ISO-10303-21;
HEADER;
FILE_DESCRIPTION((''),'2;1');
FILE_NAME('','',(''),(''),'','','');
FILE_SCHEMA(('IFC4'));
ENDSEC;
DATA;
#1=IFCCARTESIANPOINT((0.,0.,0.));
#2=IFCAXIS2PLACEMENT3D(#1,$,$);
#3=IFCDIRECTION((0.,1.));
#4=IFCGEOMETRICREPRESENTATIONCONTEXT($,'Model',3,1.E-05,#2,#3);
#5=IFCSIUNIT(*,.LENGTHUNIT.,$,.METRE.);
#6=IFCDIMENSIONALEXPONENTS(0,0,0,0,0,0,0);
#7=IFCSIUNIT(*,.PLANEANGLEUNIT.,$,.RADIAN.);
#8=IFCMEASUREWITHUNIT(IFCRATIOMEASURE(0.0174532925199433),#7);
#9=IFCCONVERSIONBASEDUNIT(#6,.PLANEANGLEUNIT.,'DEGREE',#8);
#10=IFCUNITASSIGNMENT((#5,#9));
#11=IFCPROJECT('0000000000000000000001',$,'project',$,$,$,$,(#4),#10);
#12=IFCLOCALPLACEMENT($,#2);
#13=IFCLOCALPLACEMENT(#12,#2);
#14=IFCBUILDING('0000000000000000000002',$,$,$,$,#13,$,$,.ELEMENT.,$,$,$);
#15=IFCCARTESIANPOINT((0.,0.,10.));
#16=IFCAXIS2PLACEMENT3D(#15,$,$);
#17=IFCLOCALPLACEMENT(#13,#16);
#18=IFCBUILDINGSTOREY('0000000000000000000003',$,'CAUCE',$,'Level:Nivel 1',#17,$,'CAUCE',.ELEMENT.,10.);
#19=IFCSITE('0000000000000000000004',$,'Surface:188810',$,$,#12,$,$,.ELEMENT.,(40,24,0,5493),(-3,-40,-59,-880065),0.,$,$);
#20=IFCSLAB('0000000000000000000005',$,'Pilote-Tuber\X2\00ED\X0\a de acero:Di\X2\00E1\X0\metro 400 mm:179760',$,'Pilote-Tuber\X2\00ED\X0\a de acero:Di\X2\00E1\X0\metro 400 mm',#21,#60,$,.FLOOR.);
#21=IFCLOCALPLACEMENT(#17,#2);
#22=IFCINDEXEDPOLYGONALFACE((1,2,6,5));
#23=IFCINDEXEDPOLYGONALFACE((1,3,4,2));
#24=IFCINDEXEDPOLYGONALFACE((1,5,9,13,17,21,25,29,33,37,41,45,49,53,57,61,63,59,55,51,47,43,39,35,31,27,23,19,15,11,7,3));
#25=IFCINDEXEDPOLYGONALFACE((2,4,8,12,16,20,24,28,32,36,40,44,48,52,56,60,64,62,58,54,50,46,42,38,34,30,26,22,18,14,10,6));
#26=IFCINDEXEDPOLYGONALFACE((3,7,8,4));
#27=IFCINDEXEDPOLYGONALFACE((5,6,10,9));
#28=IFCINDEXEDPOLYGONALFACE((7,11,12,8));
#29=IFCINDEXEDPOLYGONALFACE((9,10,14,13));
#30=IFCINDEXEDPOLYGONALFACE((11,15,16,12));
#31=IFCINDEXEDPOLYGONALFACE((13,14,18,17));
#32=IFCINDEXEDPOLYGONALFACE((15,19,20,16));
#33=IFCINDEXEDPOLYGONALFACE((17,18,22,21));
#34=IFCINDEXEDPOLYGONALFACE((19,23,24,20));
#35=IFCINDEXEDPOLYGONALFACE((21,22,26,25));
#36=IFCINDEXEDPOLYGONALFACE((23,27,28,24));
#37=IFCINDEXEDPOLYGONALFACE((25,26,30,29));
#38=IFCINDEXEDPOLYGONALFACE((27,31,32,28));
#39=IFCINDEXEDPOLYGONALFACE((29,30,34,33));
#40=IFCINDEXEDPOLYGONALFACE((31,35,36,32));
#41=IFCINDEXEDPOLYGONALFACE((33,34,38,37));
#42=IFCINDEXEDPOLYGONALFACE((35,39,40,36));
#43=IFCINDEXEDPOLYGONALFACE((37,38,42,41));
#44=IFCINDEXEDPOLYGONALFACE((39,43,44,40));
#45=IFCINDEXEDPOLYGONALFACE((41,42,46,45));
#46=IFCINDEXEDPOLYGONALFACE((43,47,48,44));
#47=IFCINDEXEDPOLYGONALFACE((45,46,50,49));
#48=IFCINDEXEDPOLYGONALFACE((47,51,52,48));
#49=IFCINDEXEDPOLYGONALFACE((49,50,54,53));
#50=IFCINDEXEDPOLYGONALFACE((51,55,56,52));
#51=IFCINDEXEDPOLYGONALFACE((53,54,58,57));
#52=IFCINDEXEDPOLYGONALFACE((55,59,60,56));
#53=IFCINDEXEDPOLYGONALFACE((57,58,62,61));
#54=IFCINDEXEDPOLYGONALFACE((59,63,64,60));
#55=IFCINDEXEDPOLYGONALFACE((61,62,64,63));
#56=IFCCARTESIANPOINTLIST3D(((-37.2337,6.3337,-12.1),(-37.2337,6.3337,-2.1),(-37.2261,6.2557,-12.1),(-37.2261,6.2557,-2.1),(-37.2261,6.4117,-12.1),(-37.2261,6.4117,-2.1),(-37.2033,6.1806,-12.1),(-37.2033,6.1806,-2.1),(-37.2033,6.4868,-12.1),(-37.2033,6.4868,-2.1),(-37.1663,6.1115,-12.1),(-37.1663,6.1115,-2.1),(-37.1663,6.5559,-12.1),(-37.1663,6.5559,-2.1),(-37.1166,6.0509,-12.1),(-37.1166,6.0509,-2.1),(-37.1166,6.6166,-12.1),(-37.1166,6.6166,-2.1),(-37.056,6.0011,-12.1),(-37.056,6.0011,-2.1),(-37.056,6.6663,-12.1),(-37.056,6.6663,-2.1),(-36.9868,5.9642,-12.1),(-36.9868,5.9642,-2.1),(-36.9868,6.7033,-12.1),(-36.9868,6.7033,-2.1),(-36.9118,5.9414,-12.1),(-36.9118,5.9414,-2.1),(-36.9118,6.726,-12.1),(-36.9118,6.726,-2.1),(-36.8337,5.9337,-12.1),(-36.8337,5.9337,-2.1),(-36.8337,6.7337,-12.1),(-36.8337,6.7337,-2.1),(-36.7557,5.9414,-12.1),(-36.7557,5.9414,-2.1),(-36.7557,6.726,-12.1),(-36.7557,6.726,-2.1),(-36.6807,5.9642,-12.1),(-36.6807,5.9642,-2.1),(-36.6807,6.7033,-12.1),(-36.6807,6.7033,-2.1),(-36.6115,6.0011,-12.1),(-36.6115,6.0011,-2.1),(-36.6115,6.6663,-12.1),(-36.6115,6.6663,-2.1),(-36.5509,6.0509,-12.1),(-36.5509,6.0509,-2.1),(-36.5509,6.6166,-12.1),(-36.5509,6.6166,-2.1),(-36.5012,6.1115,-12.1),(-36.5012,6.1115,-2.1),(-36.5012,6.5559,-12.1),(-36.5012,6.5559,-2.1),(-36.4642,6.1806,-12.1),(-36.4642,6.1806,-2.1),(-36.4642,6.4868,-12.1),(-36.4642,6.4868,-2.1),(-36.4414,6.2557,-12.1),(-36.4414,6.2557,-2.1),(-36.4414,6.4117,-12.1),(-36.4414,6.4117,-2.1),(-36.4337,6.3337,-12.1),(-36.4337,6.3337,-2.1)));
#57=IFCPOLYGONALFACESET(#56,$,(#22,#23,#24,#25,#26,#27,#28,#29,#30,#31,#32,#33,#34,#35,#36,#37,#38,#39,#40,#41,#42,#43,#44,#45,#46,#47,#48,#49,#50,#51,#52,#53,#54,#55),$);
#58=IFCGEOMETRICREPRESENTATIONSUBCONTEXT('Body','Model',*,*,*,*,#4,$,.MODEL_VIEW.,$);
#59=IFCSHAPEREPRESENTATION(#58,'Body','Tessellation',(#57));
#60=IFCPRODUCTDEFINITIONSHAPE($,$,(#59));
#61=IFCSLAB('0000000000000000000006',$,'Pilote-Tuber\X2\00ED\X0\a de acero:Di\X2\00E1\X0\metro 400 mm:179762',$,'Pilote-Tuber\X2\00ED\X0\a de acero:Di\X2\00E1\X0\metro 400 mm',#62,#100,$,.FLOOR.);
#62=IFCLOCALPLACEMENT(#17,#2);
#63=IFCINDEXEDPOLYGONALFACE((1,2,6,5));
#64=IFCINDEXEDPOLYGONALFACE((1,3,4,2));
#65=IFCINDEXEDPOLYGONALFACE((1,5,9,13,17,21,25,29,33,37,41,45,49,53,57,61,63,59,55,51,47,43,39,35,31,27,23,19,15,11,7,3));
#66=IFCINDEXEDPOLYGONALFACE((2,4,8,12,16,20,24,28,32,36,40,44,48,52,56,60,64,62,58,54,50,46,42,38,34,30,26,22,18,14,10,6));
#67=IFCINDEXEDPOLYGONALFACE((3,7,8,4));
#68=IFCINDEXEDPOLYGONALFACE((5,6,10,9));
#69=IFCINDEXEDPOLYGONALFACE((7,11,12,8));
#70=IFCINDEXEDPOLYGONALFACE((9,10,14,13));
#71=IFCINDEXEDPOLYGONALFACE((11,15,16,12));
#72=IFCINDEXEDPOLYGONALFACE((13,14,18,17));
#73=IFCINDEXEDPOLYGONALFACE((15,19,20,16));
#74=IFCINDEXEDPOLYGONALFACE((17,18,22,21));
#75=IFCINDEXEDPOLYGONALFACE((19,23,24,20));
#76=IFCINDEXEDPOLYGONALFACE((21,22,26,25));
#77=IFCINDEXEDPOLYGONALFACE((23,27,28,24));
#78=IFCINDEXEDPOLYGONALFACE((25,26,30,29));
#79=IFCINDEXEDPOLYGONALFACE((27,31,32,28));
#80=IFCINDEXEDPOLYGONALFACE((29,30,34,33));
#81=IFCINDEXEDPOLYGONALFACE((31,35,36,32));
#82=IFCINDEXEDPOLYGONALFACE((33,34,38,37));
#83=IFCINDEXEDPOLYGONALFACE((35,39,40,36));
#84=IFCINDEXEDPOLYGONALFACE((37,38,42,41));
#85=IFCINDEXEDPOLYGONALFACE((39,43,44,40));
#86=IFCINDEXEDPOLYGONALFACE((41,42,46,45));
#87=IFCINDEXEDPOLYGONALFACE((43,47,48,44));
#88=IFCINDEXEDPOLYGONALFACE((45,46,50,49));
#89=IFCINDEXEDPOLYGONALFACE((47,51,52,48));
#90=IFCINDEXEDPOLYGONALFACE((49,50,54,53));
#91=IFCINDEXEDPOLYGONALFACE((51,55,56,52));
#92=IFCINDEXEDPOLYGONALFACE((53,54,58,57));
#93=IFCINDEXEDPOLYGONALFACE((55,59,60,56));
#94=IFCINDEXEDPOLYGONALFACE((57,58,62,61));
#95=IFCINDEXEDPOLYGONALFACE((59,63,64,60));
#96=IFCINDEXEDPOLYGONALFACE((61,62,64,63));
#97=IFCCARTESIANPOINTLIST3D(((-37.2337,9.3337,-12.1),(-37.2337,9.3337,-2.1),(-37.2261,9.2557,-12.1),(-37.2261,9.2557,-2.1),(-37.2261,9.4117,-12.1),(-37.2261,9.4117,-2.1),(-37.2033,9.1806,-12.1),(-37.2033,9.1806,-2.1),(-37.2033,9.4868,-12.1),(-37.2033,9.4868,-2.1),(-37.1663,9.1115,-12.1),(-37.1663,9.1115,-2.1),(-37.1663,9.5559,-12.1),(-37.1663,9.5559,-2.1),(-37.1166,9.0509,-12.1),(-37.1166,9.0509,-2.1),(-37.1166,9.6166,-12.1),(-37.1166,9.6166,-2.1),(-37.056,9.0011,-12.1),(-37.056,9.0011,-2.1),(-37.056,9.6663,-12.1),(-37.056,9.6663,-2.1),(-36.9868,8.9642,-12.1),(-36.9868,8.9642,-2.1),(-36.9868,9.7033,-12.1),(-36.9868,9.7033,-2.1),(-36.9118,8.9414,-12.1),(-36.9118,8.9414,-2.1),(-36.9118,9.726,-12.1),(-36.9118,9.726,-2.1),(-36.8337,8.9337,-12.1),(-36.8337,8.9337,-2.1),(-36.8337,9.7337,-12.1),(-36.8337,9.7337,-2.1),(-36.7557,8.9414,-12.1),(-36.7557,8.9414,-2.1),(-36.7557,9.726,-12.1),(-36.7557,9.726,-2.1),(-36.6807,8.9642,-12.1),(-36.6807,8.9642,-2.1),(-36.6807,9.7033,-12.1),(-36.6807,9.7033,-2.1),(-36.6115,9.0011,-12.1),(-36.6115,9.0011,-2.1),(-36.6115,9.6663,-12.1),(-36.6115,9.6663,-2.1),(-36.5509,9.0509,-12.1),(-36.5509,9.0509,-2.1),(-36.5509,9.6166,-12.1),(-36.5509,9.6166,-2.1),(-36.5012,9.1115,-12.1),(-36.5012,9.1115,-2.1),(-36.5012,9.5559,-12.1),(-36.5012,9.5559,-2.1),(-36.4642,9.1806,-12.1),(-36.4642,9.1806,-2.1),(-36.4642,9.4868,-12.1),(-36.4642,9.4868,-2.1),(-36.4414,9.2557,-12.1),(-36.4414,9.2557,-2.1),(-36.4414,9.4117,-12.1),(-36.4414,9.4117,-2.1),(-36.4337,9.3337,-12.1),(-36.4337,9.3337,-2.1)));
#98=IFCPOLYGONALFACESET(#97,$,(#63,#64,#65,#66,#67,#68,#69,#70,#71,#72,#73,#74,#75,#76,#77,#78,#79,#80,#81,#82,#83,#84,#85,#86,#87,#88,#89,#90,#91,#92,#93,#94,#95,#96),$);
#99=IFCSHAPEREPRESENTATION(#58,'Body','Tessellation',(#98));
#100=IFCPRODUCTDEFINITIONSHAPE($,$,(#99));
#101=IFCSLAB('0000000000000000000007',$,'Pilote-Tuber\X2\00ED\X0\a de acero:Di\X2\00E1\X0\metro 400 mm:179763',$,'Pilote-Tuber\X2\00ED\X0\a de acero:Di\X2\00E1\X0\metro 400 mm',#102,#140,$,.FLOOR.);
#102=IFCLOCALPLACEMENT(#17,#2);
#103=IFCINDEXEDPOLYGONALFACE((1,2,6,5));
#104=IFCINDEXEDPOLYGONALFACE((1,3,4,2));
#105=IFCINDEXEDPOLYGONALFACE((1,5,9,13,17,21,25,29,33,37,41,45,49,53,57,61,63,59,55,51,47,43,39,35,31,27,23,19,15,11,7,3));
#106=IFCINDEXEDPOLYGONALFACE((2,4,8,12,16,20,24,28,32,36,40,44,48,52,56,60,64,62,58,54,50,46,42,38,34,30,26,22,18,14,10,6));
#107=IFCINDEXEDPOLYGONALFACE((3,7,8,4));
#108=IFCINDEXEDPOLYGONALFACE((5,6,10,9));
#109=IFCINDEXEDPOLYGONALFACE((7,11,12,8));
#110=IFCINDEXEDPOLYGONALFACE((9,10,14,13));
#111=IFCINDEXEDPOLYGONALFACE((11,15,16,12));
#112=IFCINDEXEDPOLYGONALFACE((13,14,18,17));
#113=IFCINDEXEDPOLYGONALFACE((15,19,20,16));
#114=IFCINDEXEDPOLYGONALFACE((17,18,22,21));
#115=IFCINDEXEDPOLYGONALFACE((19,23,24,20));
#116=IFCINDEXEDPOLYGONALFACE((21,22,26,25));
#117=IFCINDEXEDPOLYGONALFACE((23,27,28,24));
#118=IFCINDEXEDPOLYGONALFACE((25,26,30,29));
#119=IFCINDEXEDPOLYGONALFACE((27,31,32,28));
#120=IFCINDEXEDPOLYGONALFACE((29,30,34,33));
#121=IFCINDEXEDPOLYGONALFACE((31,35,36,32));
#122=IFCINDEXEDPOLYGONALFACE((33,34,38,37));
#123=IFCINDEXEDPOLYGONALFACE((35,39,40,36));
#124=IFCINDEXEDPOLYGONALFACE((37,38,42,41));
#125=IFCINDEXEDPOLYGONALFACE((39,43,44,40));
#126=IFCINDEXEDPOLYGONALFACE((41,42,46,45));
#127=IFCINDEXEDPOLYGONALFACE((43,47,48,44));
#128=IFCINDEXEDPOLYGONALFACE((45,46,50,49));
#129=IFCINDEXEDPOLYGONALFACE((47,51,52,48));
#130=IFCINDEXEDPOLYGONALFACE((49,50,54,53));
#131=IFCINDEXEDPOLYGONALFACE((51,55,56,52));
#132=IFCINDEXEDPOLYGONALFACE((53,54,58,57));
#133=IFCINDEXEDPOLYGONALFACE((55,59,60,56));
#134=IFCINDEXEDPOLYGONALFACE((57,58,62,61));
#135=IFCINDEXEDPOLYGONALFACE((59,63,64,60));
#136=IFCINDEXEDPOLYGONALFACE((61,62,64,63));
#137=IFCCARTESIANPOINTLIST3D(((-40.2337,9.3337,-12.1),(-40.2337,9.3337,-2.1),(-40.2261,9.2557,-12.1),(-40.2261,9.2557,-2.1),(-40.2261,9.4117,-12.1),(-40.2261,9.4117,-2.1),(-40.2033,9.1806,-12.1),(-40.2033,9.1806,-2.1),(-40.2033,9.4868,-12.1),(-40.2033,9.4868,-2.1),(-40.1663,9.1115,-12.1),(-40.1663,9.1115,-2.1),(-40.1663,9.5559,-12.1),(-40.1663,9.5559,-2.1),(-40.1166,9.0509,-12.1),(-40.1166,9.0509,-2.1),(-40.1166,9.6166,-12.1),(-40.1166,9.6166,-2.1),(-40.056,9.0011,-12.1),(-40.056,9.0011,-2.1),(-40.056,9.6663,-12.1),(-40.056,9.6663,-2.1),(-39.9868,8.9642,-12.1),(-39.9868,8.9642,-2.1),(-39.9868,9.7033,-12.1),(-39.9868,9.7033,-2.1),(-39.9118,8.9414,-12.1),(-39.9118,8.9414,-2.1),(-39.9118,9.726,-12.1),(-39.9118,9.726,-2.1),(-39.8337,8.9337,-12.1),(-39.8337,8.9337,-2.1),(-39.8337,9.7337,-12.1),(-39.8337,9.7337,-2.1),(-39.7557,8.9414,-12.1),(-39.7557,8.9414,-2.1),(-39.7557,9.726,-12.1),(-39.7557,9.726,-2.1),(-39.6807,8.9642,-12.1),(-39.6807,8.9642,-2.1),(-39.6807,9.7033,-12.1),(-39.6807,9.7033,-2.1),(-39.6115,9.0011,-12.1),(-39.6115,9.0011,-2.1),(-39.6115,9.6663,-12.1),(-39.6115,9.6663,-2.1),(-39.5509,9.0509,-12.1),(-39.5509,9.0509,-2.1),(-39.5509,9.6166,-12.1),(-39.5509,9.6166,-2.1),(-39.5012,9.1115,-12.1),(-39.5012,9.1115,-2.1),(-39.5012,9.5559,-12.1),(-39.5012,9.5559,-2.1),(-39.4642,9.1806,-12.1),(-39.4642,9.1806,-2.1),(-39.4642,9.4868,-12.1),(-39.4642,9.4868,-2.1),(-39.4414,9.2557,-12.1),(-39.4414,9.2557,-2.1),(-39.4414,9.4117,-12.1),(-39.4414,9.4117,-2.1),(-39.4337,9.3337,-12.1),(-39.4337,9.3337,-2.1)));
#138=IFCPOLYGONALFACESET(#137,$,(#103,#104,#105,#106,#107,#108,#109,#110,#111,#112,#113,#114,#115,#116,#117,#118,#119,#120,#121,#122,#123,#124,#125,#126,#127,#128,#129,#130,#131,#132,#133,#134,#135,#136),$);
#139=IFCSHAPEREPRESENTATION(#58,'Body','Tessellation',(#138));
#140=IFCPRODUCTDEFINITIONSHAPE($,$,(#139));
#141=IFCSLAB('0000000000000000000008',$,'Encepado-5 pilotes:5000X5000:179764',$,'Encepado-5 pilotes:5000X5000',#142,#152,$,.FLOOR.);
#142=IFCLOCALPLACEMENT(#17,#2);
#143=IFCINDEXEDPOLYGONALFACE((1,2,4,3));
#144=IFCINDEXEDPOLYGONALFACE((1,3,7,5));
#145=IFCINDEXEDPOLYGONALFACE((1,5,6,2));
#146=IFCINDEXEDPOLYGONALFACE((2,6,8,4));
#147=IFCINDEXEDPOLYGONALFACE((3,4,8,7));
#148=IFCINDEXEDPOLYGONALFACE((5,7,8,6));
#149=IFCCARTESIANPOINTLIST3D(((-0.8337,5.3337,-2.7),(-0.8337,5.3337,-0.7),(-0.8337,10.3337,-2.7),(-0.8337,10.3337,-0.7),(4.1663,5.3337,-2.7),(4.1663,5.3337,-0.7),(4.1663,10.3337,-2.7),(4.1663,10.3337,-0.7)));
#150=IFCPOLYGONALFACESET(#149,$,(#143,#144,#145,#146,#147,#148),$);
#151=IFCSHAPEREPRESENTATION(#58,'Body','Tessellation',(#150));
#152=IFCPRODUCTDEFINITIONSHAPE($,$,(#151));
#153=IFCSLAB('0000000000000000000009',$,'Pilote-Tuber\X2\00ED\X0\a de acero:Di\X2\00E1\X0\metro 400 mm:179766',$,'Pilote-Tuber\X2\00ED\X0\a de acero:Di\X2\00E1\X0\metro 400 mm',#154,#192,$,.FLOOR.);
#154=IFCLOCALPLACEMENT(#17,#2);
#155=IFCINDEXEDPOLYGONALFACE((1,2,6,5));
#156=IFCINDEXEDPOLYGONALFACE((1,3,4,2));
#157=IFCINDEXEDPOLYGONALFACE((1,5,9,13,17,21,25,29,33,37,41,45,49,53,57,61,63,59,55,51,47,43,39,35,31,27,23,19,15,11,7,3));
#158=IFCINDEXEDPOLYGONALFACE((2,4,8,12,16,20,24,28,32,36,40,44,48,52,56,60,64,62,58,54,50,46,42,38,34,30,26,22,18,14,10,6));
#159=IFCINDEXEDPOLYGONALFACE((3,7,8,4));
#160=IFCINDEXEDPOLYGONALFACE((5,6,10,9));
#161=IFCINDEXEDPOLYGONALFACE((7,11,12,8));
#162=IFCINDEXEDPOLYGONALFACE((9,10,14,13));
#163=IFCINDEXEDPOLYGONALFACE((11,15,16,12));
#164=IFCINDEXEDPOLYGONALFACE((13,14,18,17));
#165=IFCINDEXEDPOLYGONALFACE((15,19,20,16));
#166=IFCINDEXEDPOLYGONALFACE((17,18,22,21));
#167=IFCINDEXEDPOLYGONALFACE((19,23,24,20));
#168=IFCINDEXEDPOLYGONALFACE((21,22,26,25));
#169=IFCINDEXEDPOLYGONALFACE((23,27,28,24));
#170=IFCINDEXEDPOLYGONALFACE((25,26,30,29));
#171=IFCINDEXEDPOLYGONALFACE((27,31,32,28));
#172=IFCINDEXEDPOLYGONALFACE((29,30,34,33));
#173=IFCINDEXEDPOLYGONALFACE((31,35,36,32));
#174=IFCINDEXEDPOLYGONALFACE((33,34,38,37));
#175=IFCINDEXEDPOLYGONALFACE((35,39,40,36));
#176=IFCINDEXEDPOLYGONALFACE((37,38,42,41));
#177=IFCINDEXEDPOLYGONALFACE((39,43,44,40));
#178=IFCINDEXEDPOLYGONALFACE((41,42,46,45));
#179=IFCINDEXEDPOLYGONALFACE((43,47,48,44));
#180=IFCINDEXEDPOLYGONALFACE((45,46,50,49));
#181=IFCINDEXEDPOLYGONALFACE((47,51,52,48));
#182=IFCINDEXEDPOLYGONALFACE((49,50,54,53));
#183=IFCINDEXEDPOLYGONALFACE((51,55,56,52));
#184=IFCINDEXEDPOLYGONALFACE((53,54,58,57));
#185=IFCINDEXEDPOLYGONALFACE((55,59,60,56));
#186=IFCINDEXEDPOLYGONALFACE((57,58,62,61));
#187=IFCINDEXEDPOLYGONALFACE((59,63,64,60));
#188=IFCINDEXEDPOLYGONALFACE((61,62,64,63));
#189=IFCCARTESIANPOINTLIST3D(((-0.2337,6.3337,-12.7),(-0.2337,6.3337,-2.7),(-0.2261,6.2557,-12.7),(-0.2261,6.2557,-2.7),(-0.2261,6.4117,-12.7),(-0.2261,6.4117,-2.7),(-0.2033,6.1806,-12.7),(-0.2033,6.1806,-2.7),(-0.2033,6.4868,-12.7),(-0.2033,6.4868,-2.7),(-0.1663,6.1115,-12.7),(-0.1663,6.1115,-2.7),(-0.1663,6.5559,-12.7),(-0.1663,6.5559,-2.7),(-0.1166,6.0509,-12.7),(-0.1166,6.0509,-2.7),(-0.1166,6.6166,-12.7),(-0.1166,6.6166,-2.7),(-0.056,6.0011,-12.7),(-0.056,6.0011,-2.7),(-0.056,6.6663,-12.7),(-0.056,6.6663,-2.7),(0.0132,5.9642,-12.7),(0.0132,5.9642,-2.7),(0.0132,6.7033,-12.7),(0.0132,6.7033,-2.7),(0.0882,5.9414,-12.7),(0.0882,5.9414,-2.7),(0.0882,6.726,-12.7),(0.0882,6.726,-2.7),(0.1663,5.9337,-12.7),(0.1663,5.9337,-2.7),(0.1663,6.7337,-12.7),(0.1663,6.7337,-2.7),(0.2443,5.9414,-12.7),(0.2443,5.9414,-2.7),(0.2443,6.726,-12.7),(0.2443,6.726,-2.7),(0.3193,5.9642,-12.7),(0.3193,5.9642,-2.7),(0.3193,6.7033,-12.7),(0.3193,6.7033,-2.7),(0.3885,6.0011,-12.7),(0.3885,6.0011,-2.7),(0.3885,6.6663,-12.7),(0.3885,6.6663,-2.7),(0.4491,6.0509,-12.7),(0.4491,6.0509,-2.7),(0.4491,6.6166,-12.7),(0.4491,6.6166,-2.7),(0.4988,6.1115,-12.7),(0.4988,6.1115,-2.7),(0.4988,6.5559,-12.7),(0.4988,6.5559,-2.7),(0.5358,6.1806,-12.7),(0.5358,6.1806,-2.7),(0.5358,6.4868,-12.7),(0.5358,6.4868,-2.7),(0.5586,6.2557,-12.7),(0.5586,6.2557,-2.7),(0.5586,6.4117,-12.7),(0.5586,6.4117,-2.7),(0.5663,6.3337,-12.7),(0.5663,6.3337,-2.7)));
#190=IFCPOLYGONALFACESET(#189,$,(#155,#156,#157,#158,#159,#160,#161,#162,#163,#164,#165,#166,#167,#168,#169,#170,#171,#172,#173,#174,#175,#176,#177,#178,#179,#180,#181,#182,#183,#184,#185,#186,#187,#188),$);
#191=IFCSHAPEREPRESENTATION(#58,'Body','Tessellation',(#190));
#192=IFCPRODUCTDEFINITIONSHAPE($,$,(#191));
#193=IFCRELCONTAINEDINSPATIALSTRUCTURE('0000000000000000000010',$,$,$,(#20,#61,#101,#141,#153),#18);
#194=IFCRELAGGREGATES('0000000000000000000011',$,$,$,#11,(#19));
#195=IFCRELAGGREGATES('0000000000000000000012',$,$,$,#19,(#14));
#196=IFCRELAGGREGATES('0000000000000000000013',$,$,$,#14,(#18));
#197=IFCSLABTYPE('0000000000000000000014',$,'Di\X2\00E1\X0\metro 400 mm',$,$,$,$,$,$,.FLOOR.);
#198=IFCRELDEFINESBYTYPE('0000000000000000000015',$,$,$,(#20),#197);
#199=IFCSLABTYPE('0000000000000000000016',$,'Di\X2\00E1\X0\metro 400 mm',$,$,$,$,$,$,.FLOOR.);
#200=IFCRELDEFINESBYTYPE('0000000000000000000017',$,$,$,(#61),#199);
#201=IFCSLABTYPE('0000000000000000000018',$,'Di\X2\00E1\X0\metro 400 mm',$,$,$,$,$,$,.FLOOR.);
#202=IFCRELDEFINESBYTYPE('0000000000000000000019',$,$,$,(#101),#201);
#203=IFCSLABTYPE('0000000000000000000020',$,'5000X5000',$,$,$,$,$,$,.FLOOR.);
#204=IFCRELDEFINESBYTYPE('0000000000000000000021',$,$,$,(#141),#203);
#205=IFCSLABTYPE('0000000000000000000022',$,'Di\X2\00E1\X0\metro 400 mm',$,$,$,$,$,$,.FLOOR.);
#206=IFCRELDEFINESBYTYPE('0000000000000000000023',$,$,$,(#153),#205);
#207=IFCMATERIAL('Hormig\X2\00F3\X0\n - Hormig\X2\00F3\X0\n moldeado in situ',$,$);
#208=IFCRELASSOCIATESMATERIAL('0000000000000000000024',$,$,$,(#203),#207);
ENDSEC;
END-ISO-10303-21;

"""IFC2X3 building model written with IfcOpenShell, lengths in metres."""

from ifc_helpers import new_model, entity, si_unit, converted_unit, direction, frame, origin, origin_2d_with_axis, place, context, subcontext, project, spatial, rectangle, circle, extrude, material, type_object, element, save


model = new_model("IFC2X3")

# Units and contexts
model_context = context("Model", 3, precision=1e-05, world=origin(), true_north=direction((0.0, 1.0)))
body_context = subcontext(model_context, "Body", "Model", "MODEL_VIEW")
ifc_project = project(units=[si_unit("LENGTHUNIT", "METRE"), converted_unit("PLANEANGLEUNIT", "DEGREE", entity("IfcRatioMeasure", 0.0174532925199433), si_unit("PLANEANGLEUNIT", "RADIAN"), dimensions=[0, 0, 0, 0, 0, 0, 0])], contexts=[model_context])

# Site, building, storey
site_placement = place(None, origin())
site = spatial("IfcSite", under=ifc_project, at=site_placement, Name="Surface:188810", CompositionType="ELEMENT", RefLatitude=(40, 24, 0, 5493), RefLongitude=(-3, -40, -59, -880065), RefElevation=0.0)
building_placement = place(site_placement, origin())
building = spatial("IfcBuilding", under=site, at=building_placement, CompositionType="ELEMENT")
storey_placement = place(building_placement, frame((0.0, 0.0, 10.0)))
storey = spatial("IfcBuildingStorey", under=building, at=storey_placement, Name="CAUCE", ObjectType="Level:Nivel 1", LongName="CAUCE", CompositionType="ELEMENT", Elevation=10.0)

# Slabs
ifc_material = material(Name="Hormigón - Hormigón moldeado in situ")
slab_type_1 = type_object("IfcSlabType", Name="Diámetro 400 mm", PredefinedType="FLOOR")
slab_1_placement = place(storey_placement, origin())
element("IfcSlab", 1, at=slab_1_placement, inside=storey, type_object=slab_type_1, Name="Pilote-Tubería de acero:Diámetro 400 mm:179760", ObjectType="Pilote-Tubería de acero:Diámetro 400 mm", PredefinedType="FLOOR", context=body_context, shape_type="SweptSolid", body=[
    extrude(circle(Radius=0.4, at=origin_2d_with_axis()), frame((-36.8337, 6.3337, -12.1)), (0.0, 0.0, 1.0), 10.0),
])
slab_type_2 = type_object("IfcSlabType", Name="Diámetro 400 mm", PredefinedType="FLOOR")
slab_2_placement = place(storey_placement, origin())
element("IfcSlab", 2, at=slab_2_placement, inside=storey, type_object=slab_type_2, Name="Pilote-Tubería de acero:Diámetro 400 mm:179762", ObjectType="Pilote-Tubería de acero:Diámetro 400 mm", PredefinedType="FLOOR", context=body_context, shape_type="SweptSolid", body=[
    extrude(circle(Radius=0.4, at=origin_2d_with_axis()), frame((-36.8337, 9.3337, -12.1)), (0.0, 0.0, 1.0), 10.0),
])
slab_type_3 = type_object("IfcSlabType", Name="Diámetro 400 mm", PredefinedType="FLOOR")
slab_3_placement = place(storey_placement, origin())
element("IfcSlab", 3, at=slab_3_placement, inside=storey, type_object=slab_type_3, Name="Pilote-Tubería de acero:Diámetro 400 mm:179763", ObjectType="Pilote-Tubería de acero:Diámetro 400 mm", PredefinedType="FLOOR", context=body_context, shape_type="SweptSolid", body=[
    extrude(circle(Radius=0.4, at=origin_2d_with_axis()), frame((-39.8337, 9.3337, -12.1)), (0.0, 0.0, 1.0), 10.0),
])
slab_type_4 = type_object("IfcSlabType", Name="5000X5000", PredefinedType="FLOOR", material=ifc_material)
slab_4_placement = place(storey_placement, origin())
element("IfcSlab", 4, at=slab_4_placement, inside=storey, type_object=slab_type_4, Name="Encepado-5 pilotes:5000X5000:179764", ObjectType="Encepado-5 pilotes:5000X5000", PredefinedType="FLOOR", context=body_context, shape_type="SweptSolid", body=[
    extrude(rectangle(XDim=5.0, YDim=5.0, at=origin_2d_with_axis()), frame((1.6663, 7.8337, -2.7), z_axis=(0.0, 0.0, 1.0), x_axis=(-1.0, 0.0, 0.0)), (0.0, 0.0, 1.0), 2.0),
])
slab_type_5 = type_object("IfcSlabType", Name="Diámetro 400 mm", PredefinedType="FLOOR")
slab_5_placement = place(storey_placement, origin())
element("IfcSlab", 5, at=slab_5_placement, inside=storey, type_object=slab_type_5, Name="Pilote-Tubería de acero:Diámetro 400 mm:179766", ObjectType="Pilote-Tubería de acero:Diámetro 400 mm", PredefinedType="FLOOR", context=body_context, shape_type="SweptSolid", body=[
    extrude(circle(Radius=0.4, at=origin_2d_with_axis()), frame((0.1663, 6.3337, -12.7)), (0.0, 0.0, 1.0), 10.0),
])

save(model, "model.ifc")
